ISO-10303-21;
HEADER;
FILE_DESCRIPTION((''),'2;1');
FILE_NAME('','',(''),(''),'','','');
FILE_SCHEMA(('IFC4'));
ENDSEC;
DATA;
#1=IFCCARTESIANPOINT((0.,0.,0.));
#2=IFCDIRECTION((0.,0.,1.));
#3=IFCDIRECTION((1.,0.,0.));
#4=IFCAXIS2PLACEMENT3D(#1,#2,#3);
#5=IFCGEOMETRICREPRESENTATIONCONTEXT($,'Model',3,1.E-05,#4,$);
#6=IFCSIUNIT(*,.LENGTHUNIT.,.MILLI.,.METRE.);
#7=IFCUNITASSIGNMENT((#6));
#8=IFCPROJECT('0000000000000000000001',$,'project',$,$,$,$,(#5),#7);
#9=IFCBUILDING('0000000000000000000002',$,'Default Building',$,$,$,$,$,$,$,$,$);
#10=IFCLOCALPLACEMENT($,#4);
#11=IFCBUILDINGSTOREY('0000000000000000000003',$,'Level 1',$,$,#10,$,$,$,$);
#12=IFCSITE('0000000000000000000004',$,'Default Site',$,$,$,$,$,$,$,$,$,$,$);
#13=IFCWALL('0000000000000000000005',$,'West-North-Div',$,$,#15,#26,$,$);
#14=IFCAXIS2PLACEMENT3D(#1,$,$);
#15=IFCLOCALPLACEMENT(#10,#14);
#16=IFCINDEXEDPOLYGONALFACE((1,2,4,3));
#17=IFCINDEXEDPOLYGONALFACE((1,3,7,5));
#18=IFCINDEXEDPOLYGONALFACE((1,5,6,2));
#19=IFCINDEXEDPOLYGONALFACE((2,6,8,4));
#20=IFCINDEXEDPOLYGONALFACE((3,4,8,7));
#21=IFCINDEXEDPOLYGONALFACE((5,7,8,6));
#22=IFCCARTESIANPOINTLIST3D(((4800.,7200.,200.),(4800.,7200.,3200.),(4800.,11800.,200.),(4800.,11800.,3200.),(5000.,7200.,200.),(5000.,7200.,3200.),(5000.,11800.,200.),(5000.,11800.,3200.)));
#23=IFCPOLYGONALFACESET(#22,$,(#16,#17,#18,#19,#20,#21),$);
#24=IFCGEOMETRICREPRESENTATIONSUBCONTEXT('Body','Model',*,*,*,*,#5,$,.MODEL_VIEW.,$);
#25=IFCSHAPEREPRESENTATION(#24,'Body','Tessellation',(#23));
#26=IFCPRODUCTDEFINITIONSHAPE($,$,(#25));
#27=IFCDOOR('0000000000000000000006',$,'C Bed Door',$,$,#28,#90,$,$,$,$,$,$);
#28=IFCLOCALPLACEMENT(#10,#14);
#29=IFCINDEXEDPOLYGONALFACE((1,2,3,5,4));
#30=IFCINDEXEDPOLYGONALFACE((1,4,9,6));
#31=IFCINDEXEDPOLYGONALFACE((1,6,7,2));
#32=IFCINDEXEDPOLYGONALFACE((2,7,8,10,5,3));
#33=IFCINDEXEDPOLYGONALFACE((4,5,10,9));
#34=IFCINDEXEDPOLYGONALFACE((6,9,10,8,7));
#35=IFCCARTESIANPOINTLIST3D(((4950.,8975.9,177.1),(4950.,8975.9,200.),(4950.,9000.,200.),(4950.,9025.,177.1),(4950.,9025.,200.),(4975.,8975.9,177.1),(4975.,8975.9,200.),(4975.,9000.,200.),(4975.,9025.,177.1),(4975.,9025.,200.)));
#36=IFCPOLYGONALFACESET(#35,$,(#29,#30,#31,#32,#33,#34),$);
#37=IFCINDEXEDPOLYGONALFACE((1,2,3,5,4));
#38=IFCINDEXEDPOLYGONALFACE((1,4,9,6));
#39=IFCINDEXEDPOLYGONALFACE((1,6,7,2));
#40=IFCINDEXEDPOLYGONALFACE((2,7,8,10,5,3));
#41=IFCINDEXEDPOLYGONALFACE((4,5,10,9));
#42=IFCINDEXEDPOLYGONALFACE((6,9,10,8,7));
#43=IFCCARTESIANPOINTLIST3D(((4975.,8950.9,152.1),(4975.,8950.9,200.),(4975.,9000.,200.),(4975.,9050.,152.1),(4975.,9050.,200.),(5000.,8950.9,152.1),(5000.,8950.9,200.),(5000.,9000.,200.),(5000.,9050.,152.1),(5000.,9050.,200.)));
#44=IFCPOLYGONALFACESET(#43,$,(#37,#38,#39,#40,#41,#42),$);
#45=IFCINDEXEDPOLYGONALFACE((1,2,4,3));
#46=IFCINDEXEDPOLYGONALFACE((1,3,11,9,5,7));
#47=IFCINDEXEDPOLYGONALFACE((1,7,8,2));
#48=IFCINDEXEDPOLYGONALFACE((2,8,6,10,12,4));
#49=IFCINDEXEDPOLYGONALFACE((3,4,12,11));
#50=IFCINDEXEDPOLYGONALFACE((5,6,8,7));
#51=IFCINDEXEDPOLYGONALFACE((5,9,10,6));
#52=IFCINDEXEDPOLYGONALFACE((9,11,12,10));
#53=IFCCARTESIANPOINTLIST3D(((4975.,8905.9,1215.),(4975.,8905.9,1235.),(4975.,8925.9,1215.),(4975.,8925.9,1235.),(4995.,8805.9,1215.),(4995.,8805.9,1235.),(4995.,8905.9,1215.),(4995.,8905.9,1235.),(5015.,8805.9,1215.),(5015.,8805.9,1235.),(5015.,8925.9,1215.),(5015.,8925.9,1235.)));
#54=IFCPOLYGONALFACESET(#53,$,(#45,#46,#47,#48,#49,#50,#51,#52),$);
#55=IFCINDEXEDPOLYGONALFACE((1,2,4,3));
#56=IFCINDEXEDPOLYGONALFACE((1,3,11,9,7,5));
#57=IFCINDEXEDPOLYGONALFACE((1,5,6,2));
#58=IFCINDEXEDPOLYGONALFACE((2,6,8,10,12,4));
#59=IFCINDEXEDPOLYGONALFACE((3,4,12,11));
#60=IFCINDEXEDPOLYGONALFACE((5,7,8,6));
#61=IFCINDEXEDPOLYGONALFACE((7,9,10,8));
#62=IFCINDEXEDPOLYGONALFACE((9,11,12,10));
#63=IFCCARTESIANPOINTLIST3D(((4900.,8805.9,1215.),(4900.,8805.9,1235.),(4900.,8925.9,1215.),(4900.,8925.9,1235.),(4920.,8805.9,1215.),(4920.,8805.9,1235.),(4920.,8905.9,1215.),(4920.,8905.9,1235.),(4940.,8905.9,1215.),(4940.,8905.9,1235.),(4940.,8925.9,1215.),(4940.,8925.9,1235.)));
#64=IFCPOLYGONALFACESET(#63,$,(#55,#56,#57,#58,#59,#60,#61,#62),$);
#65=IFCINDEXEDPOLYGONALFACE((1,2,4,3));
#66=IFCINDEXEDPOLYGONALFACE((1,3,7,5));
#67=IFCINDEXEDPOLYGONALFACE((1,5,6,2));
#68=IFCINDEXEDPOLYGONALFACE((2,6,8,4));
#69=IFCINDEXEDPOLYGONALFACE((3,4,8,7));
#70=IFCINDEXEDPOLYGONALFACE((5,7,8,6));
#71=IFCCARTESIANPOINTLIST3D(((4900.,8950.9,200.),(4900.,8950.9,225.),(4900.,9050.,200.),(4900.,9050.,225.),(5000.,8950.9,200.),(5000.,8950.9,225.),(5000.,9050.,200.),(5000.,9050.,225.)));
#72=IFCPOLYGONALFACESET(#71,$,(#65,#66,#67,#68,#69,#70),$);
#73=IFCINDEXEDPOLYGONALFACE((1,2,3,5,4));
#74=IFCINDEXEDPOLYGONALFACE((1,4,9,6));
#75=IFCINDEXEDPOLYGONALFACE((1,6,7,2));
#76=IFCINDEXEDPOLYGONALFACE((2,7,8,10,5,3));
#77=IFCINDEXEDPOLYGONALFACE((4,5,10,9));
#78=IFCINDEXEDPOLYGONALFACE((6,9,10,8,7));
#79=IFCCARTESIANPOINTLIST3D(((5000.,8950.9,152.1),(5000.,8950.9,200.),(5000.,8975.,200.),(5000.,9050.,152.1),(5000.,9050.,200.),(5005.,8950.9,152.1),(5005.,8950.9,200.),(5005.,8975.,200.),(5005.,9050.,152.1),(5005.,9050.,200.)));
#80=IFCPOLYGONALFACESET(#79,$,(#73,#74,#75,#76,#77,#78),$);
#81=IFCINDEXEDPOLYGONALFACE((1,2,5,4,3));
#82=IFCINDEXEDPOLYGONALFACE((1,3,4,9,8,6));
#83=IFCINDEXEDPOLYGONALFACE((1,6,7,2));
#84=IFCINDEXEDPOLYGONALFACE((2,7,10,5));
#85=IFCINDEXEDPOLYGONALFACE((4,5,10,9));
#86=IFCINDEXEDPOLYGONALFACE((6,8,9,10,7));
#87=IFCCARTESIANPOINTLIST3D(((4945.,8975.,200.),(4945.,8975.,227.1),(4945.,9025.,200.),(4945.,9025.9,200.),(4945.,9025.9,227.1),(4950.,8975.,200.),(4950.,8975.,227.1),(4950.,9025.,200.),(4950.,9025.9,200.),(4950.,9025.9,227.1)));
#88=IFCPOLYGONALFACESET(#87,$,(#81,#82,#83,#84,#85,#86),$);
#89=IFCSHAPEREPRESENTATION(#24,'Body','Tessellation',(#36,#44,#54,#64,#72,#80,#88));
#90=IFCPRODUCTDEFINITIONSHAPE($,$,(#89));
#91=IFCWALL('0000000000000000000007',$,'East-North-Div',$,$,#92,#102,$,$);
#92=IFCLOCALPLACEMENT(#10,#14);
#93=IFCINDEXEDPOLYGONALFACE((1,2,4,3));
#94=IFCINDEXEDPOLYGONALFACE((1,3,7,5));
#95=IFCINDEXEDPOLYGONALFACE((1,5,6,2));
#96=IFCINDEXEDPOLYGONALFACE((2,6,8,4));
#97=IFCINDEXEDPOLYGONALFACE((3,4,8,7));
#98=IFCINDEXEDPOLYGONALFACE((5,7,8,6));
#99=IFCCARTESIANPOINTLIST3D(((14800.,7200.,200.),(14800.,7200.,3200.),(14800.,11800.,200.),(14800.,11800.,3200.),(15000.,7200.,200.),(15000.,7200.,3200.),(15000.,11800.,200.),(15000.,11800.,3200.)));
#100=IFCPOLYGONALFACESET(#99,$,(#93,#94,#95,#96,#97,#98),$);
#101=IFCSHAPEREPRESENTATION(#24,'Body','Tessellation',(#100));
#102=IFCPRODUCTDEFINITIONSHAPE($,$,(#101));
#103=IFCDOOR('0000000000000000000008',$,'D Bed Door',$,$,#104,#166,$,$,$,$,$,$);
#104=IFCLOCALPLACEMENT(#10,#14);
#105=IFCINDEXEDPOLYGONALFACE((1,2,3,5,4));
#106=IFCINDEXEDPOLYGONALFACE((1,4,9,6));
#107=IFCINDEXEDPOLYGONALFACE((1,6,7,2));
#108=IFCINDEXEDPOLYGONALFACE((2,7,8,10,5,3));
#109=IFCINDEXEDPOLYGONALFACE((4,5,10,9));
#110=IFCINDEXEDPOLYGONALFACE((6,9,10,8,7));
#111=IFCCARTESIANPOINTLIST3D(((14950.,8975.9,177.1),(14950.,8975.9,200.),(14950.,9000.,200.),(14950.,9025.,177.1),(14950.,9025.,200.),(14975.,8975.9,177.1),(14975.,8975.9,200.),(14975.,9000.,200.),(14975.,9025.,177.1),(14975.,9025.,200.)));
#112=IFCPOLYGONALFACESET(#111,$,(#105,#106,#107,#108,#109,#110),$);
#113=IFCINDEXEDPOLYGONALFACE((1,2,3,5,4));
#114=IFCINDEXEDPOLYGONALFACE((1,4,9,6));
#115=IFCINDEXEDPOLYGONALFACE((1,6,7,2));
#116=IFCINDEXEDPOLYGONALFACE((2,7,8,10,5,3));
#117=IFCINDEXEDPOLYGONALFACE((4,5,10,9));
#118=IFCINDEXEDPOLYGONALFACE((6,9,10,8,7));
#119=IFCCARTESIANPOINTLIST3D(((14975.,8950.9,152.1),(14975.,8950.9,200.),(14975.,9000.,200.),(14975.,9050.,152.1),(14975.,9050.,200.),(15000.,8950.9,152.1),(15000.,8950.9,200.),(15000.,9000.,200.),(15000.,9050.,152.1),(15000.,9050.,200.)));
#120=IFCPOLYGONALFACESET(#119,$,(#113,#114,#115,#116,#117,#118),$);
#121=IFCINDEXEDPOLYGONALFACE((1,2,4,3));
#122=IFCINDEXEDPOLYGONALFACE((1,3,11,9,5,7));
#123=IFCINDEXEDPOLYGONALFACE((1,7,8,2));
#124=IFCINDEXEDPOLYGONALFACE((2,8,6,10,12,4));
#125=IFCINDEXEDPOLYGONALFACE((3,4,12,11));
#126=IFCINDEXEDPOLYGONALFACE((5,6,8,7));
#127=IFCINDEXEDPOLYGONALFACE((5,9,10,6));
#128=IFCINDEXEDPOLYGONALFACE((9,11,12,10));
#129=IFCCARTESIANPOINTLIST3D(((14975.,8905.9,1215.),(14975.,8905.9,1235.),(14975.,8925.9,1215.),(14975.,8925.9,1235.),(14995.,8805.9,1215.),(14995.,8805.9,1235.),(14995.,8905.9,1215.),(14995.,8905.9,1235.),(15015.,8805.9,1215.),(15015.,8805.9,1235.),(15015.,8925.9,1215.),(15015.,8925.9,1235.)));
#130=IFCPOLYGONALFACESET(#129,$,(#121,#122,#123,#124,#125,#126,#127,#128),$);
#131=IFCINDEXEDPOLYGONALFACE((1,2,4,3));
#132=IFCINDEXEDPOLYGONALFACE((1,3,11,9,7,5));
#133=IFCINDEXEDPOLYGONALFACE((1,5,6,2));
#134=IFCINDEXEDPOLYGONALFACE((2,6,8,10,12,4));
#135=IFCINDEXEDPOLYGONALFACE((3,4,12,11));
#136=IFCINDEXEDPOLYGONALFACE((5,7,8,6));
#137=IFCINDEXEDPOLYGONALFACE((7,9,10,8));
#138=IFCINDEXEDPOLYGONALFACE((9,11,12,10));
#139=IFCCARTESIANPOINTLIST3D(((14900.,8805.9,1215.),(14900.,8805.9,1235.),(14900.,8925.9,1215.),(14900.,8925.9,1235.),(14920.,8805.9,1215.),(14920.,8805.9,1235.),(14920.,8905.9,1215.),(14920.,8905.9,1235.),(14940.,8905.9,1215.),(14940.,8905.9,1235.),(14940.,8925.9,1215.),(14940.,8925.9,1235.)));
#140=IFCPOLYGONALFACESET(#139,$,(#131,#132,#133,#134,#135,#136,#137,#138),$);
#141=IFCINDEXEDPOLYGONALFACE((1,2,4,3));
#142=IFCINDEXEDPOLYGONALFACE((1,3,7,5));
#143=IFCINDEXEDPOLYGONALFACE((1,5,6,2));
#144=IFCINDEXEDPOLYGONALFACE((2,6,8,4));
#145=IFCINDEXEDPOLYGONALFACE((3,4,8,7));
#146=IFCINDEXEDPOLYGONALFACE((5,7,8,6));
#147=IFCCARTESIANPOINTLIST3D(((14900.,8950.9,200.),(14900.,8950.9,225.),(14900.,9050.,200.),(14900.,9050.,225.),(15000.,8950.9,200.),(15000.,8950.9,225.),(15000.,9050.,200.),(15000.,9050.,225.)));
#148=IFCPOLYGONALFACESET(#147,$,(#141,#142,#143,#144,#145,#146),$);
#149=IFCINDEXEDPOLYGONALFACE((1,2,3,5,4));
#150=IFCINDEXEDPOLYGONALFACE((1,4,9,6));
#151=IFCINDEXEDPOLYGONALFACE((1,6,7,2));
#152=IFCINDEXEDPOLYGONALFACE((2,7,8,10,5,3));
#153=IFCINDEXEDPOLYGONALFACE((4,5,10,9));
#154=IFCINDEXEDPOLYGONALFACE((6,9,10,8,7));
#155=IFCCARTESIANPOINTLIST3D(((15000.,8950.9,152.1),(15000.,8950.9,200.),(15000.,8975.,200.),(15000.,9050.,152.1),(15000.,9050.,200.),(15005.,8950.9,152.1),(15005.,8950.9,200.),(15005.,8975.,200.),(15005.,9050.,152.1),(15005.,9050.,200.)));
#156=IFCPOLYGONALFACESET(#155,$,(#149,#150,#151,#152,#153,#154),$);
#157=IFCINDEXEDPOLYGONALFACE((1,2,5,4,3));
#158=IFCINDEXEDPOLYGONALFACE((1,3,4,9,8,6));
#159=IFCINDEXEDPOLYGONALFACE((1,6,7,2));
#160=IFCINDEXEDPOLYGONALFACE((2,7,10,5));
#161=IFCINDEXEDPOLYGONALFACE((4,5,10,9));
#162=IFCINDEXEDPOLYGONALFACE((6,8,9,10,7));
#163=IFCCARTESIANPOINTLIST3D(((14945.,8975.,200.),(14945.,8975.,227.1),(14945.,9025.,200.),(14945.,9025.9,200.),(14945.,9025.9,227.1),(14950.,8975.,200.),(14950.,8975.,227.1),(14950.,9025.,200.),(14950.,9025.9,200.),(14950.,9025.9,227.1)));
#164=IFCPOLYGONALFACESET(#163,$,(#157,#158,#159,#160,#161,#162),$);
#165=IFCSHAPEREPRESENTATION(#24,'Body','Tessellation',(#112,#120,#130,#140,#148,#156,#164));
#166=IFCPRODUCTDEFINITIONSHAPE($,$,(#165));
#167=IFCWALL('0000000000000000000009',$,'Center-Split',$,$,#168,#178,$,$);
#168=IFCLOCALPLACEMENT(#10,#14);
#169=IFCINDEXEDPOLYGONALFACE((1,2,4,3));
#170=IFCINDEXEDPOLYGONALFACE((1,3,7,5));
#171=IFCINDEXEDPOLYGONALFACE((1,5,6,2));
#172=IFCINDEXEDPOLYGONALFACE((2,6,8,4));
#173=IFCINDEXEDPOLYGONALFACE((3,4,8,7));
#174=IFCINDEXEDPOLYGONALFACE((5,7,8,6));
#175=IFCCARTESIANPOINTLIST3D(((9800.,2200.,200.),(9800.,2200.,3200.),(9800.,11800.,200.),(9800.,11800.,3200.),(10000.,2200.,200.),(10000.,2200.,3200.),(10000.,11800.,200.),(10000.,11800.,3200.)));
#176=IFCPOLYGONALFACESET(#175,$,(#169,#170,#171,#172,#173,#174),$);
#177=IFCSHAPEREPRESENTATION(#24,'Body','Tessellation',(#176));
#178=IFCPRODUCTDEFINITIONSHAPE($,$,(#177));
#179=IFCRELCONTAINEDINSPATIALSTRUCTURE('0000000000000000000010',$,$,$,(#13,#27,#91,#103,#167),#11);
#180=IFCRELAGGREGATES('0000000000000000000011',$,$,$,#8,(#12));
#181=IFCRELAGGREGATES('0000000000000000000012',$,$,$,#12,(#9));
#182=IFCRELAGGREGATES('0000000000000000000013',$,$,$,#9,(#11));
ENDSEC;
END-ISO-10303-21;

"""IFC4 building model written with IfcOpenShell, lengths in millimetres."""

from ifc_helpers import new_model, si_unit, frame, origin_with_axes, place, context, subcontext, project, spatial, line, indexed_curve, outline, extrude, element, fill, save


model = new_model("IFC4")

# Units and contexts
model_context = context("Model", 3, precision=1e-05, world=origin_with_axes())
body_context = subcontext(model_context, "Body", "Model", "MODEL_VIEW")
ifc_project = project(units=[si_unit("LENGTHUNIT", "METRE", prefix="MILLI")], contexts=[model_context])

# Site, building, storey
site = spatial("IfcSite", under=ifc_project, Name="Default Site")
building = spatial("IfcBuilding", under=site, Name="Default Building")
storey_placement = place(None, origin_with_axes())
storey = spatial("IfcBuildingStorey", under=building, at=storey_placement, Name="Level 1")

# Walls, openings, doors
wall_1_placement = place(storey_placement, frame((0.0, 0.0, 200.0), z_axis=(0.0, 0.0, 1.0), x_axis=(1.0, 0.0, 0.0)))
wall_1 = element("IfcWall", 1, at=wall_1_placement, inside=storey, Name="West-North-Div", context=body_context, shape_type="SweptSolid", body=[
    extrude(outline(indexed_curve([(5000.0, 7200.0), (5000.0, 11800.0), (4800.0, 11800.0), (4800.0, 7200.0), (5000.0, 7200.0)])), None, (0.0, 0.0, 1.0), 3000.0),
])
opening_1_placement = place(wall_1_placement, origin_with_axes())
opening_1 = element("IfcOpeningElement", 2, at=opening_1_placement, cuts=wall_1, context=body_context, shape_type="SweptSolid", body=[
    extrude(outline(indexed_curve([(5000.0, 9000.0), (5200.0, 9000.0), (5200.0, 9900.0), (5000.0, 9900.0), (5000.0, 9000.0)])), None, (0.0, 0.0, 1.0), 2100.0),
])
door_1_placement = place(storey_placement, frame((5000.0, 9000.0, 200.0), z_axis=(0.0, 0.0, 1.0), x_axis=(0.0, 1.0, 0.0)))
door_1 = element("IfcDoor", 3, at=door_1_placement, inside=storey, Name="C Bed Door", context=body_context, shape_type="SweptSolid", body=[
    extrude(outline(indexed_curve([(0.0, 0.0), (0.0, 2.1), (0.9, 2.1), (0.9, 0.0), (-24.1, 0.0), (-24.1, -22.9), (25.0, -22.9), (25.0, 0.0)], segments=[line(1, 2, 3, 4, 5, 6, 7, 8, 1)])), frame((0.0, 25.0, 0.0), z_axis=(0.0, -1.0, 0.0), x_axis=(1.0, 0.0, 0.0)), (0.0, 0.0, -1.0), 25.0),
    extrude(outline(indexed_curve([(0.0, 0.0), (0.0, 2.1), (0.9, 2.1), (0.9, 0.0), (-49.1, 0.0), (-49.1, -47.9), (50.0, -47.9), (50.0, 0.0)], segments=[line(1, 2, 3, 4, 5, 6, 7, 8, 1)])), frame((0.0, 0.0, 0.0), z_axis=(0.0, -1.0, 0.0), x_axis=(1.0, 0.0, 0.0)), (0.0, 0.0, -1.0), 25.0),
    extrude(outline(indexed_curve([(0.0, 0.0), (-49.1, 0.0), (-49.1, 35.0), (0.0, 35.0)], segments=[line(1, 2, 3, 4, 1)])), frame((25.0, 25.0, 25.0), z_axis=(0.0, 0.0, 1.0), x_axis=(1.0, 0.0, 0.0)), (0.0, 0.0, 1.0), -47.9),
    extrude(outline(indexed_curve([(0.0, 0.0), (0.0, -40.0), (-120.0, -40.0), (-120.0, -20.0), (-20.0, -20.0), (-20.0, 0.0)], segments=[line(1, 2, 3, 4, 5, 6, 1)])), frame((-74.1, 25.0, 1015.0), z_axis=(0.0, 0.0, 1.0), x_axis=(1.0, 0.0, 0.0)), (0.0, 0.0, 1.0), 20.0),
    extrude(outline(indexed_curve([(0.0, 0.0), (0.0, 40.0), (-120.0, 40.0), (-120.0, 20.0), (-20.0, 20.0), (-20.0, 0.0)], segments=[line(1, 2, 3, 4, 5, 6, 1)])), frame((-74.1, 60.0, 1015.0), z_axis=(0.0, 0.0, 1.0), x_axis=(1.0, 0.0, 0.0)), (0.0, 0.0, 1.0), 20.0),
    extrude(outline(indexed_curve([(0.0, 0.0), (-99.1, 0.0), (-99.1, 100.0), (0.0, 100.0)], segments=[line(1, 2, 3, 4, 1)])), frame((50.0, 0.0, 0.0), z_axis=(0.0, 0.0, 1.0), x_axis=(1.0, 0.0, 0.0)), (0.0, 0.0, 1.0), 25.0),
    extrude(outline(indexed_curve([(0.0, 0.0), (0.0, 27.1), (50.9, 27.1), (50.9, 0.0), (-24.1, 0.0), (-24.1, -47.9), (75.0, -47.9), (75.0, 0.0)], segments=[line(1, 2, 3, 4, 5, 6, 7, 8, 1)])), frame((-25.0, -5.0, 0.0), z_axis=(0.0, -1.0, 0.0), x_axis=(1.0, 0.0, 0.0)), (0.0, 0.0, -1.0), 5.0),
    extrude(outline(indexed_curve([(0.0, 0.0), (0.0, 27.1), (50.9, 27.1), (50.9, 0.0), (0.9, 0.0), (0.9, -22.9), (50.0, -22.9), (50.0, 0.0)], segments=[line(1, 2, 3, 4, 5, 6, 7, 8, 1)])), frame((-25.0, 50.0, 0.0), z_axis=(0.0, -1.0, 0.0), x_axis=(1.0, 0.0, 0.0)), (0.0, 0.0, -1.0), 5.0),
])
fill(opening_1, door_1)
wall_2_placement = place(storey_placement, frame((0.0, 0.0, 200.0), z_axis=(0.0, 0.0, 1.0), x_axis=(1.0, 0.0, 0.0)))
wall_2 = element("IfcWall", 4, at=wall_2_placement, inside=storey, Name="East-North-Div", context=body_context, shape_type="SweptSolid", body=[
    extrude(outline(indexed_curve([(15000.0, 7200.0), (15000.0, 11800.0), (14800.0, 11800.0), (14800.0, 7200.0), (15000.0, 7200.0)])), None, (0.0, 0.0, 1.0), 3000.0),
])
opening_2_placement = place(wall_2_placement, origin_with_axes())
opening_2 = element("IfcOpeningElement", 5, at=opening_2_placement, cuts=wall_2, context=body_context, shape_type="SweptSolid", body=[
    extrude(outline(indexed_curve([(15000.0, 9000.0), (15200.0, 9000.0), (15200.0, 9900.0), (15000.0, 9900.0), (15000.0, 9000.0)])), None, (0.0, 0.0, 1.0), 2100.0),
])
door_2_placement = place(storey_placement, frame((15000.0, 9000.0, 200.0), z_axis=(0.0, 0.0, 1.0), x_axis=(0.0, 1.0, 0.0)))
door_2 = element("IfcDoor", 6, at=door_2_placement, inside=storey, Name="D Bed Door", context=body_context, shape_type="SweptSolid", body=[
    extrude(outline(indexed_curve([(0.0, 0.0), (0.0, 2.1), (0.9, 2.1), (0.9, 0.0), (-24.1, 0.0), (-24.1, -22.9), (25.0, -22.9), (25.0, 0.0)], segments=[line(1, 2, 3, 4, 5, 6, 7, 8, 1)])), frame((0.0, 25.0, 0.0), z_axis=(0.0, -1.0, 0.0), x_axis=(1.0, 0.0, 0.0)), (0.0, 0.0, -1.0), 25.0),
    extrude(outline(indexed_curve([(0.0, 0.0), (0.0, 2.1), (0.9, 2.1), (0.9, 0.0), (-49.1, 0.0), (-49.1, -47.9), (50.0, -47.9), (50.0, 0.0)], segments=[line(1, 2, 3, 4, 5, 6, 7, 8, 1)])), frame((0.0, 0.0, 0.0), z_axis=(0.0, -1.0, 0.0), x_axis=(1.0, 0.0, 0.0)), (0.0, 0.0, -1.0), 25.0),
    extrude(outline(indexed_curve([(0.0, 0.0), (-49.1, 0.0), (-49.1, 35.0), (0.0, 35.0)], segments=[line(1, 2, 3, 4, 1)])), frame((25.0, 25.0, 25.0), z_axis=(0.0, 0.0, 1.0), x_axis=(1.0, 0.0, 0.0)), (0.0, 0.0, 1.0), -47.9),
    extrude(outline(indexed_curve([(0.0, 0.0), (0.0, -40.0), (-120.0, -40.0), (-120.0, -20.0), (-20.0, -20.0), (-20.0, 0.0)], segments=[line(1, 2, 3, 4, 5, 6, 1)])), frame((-74.1, 25.0, 1015.0), z_axis=(0.0, 0.0, 1.0), x_axis=(1.0, 0.0, 0.0)), (0.0, 0.0, 1.0), 20.0),
    extrude(outline(indexed_curve([(0.0, 0.0), (0.0, 40.0), (-120.0, 40.0), (-120.0, 20.0), (-20.0, 20.0), (-20.0, 0.0)], segments=[line(1, 2, 3, 4, 5, 6, 1)])), frame((-74.1, 60.0, 1015.0), z_axis=(0.0, 0.0, 1.0), x_axis=(1.0, 0.0, 0.0)), (0.0, 0.0, 1.0), 20.0),
    extrude(outline(indexed_curve([(0.0, 0.0), (-99.1, 0.0), (-99.1, 100.0), (0.0, 100.0)], segments=[line(1, 2, 3, 4, 1)])), frame((50.0, 0.0, 0.0), z_axis=(0.0, 0.0, 1.0), x_axis=(1.0, 0.0, 0.0)), (0.0, 0.0, 1.0), 25.0),
    extrude(outline(indexed_curve([(0.0, 0.0), (0.0, 27.1), (50.9, 27.1), (50.9, 0.0), (-24.1, 0.0), (-24.1, -47.9), (75.0, -47.9), (75.0, 0.0)], segments=[line(1, 2, 3, 4, 5, 6, 7, 8, 1)])), frame((-25.0, -5.0, 0.0), z_axis=(0.0, -1.0, 0.0), x_axis=(1.0, 0.0, 0.0)), (0.0, 0.0, -1.0), 5.0),
    extrude(outline(indexed_curve([(0.0, 0.0), (0.0, 27.1), (50.9, 27.1), (50.9, 0.0), (0.9, 0.0), (0.9, -22.9), (50.0, -22.9), (50.0, 0.0)], segments=[line(1, 2, 3, 4, 5, 6, 7, 8, 1)])), frame((-25.0, 50.0, 0.0), z_axis=(0.0, -1.0, 0.0), x_axis=(1.0, 0.0, 0.0)), (0.0, 0.0, -1.0), 5.0),
])
fill(opening_2, door_2)

# Wall
wall_3_placement = place(storey_placement, frame((0.0, 0.0, 200.0), z_axis=(0.0, 0.0, 1.0), x_axis=(1.0, 0.0, 0.0)))
element("IfcWall", 7, at=wall_3_placement, inside=storey, Name="Center-Split", context=body_context, shape_type="SweptSolid", body=[
    extrude(outline(indexed_curve([(10000.0, 2200.0), (10000.0, 11800.0), (9800.0, 11800.0), (9800.0, 2200.0), (10000.0, 2200.0)])), None, (0.0, 0.0, 1.0), 3000.0),
])

save(model, "model.ifc")
